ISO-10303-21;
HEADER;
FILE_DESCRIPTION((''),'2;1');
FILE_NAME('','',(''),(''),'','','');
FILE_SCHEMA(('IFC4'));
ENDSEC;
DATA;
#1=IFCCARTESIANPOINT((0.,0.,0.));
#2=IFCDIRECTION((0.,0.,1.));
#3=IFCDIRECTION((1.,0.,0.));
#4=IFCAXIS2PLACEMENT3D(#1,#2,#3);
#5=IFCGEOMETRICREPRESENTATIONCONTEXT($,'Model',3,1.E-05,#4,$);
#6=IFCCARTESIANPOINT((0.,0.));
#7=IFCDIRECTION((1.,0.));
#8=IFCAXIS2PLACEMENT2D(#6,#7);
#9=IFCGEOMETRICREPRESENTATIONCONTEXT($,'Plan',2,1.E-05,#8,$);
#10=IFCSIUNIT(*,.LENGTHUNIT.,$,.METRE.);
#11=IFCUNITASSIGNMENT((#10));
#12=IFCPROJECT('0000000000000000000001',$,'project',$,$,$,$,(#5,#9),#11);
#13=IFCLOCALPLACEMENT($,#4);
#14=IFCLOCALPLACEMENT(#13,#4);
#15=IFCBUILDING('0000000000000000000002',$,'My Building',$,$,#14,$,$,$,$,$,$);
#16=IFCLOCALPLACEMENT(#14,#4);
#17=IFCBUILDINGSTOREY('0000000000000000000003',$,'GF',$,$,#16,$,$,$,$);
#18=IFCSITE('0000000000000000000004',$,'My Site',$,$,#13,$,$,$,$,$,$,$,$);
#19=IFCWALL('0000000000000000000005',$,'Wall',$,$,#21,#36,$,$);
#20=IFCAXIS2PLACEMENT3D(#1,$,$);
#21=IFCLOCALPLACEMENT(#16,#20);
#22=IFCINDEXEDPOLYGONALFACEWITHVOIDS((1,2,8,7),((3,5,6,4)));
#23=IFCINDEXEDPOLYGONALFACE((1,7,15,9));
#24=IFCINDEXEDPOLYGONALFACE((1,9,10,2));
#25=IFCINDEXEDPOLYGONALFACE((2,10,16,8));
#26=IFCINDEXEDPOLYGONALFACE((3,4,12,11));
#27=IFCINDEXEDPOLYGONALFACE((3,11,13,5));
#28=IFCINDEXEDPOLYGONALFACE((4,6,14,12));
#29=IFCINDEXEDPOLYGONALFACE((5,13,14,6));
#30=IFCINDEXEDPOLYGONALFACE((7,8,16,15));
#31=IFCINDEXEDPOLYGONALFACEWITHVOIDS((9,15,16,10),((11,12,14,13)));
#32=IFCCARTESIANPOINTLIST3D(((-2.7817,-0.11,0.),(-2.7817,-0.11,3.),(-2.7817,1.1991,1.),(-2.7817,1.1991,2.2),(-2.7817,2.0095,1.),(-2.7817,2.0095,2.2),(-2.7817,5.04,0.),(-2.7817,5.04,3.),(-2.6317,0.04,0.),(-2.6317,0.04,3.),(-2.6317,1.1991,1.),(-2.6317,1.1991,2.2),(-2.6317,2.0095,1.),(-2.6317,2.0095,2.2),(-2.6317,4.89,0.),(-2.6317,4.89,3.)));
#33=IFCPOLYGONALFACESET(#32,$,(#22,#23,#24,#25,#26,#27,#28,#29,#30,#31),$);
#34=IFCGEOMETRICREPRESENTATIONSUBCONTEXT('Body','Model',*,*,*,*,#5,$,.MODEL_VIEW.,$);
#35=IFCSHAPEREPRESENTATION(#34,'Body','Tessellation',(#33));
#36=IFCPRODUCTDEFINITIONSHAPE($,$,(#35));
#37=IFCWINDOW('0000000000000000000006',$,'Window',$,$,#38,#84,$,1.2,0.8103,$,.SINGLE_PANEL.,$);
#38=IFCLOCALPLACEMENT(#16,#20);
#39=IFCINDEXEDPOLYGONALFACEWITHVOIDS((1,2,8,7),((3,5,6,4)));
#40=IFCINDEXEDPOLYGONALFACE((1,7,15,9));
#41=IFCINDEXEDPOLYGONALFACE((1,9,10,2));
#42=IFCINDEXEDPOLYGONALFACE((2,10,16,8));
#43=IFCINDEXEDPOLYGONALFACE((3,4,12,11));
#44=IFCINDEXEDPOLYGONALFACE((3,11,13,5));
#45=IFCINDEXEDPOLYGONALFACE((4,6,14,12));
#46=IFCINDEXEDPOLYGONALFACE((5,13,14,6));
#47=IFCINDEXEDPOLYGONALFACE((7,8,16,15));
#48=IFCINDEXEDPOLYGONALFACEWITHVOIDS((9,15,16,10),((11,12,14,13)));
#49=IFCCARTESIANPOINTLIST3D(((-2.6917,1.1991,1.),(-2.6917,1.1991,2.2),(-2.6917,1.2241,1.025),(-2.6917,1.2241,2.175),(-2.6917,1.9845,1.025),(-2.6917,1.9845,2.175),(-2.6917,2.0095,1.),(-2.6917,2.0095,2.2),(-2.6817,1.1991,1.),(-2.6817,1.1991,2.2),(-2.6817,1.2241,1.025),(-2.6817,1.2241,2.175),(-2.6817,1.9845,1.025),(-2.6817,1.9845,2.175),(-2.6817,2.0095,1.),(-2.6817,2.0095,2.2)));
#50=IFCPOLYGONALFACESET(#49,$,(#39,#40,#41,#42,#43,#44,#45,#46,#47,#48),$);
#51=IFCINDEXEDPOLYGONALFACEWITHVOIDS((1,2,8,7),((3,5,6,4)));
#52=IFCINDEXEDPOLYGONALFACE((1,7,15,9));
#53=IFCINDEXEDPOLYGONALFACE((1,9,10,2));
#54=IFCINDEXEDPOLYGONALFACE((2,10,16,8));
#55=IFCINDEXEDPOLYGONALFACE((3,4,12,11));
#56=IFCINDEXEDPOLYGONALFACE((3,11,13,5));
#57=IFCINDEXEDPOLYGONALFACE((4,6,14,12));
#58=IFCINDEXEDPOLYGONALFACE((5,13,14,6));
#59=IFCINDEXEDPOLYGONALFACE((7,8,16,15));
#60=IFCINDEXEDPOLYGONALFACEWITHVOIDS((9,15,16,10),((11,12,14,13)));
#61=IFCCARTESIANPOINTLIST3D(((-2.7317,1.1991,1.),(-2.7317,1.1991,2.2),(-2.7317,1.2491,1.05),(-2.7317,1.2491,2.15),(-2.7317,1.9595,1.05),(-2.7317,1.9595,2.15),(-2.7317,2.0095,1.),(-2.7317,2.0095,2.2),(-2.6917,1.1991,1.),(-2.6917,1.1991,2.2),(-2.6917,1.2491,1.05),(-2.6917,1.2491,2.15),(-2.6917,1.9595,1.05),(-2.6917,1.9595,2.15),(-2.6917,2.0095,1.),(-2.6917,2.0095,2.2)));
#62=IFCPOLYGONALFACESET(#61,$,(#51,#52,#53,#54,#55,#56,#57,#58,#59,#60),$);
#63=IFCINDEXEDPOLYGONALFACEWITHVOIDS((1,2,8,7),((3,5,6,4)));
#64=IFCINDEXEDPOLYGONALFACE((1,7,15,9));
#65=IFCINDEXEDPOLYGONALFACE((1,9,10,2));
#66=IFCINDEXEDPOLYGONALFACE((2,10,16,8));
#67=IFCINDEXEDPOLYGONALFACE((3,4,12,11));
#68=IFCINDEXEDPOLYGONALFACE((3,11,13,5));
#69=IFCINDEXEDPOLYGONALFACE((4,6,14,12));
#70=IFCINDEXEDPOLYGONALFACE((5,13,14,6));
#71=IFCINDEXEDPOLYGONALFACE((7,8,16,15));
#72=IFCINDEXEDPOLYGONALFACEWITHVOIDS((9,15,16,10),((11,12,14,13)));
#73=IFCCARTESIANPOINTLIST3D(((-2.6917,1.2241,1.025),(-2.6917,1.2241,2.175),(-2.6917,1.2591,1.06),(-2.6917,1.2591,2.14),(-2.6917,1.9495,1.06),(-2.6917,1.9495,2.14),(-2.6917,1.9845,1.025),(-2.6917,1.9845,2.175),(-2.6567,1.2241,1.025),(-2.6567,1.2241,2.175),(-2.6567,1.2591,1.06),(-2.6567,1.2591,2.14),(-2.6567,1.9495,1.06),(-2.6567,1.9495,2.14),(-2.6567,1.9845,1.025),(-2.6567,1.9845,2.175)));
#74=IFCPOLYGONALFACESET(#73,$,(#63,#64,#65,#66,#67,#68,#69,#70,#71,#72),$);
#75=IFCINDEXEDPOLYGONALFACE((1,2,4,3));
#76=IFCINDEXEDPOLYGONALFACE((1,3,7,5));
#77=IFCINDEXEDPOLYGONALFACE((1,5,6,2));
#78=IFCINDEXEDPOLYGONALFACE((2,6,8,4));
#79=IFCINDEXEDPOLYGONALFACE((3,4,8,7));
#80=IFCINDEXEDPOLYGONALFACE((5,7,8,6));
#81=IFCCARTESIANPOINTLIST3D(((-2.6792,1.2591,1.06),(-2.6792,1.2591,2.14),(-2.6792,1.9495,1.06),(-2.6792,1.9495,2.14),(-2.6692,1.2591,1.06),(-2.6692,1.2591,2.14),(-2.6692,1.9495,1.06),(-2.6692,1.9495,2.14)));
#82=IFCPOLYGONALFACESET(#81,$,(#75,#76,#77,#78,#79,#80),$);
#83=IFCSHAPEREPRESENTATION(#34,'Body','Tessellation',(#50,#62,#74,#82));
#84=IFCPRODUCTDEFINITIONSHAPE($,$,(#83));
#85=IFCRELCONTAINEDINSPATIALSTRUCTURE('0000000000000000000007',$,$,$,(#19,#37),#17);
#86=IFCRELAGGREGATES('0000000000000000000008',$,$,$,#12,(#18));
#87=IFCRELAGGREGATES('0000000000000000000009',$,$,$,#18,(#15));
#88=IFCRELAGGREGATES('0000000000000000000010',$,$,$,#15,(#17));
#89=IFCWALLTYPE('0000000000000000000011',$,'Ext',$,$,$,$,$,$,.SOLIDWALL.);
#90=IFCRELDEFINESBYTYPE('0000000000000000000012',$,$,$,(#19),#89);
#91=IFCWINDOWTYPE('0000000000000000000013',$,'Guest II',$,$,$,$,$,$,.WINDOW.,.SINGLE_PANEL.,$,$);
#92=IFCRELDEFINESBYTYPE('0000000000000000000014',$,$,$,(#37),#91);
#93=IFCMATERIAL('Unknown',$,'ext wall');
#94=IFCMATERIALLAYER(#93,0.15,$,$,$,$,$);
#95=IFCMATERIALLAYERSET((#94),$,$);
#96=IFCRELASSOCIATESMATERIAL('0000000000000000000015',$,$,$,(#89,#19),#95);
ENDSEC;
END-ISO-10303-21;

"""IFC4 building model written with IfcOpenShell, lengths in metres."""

from ifc_helpers import new_model, entity, si_unit, frame, origin_with_axes, origin_2d_with_axis, place, context, subcontext, project, spatial, line, indexed_curve, outline, extrude, shape, source, transform, mapped, material, layer, layer_set, layer_usage, type_object, type_shapes, element, fill, save


model = new_model("IFC4")

# Units and contexts
model_context = context("Model", 3, precision=1e-05, world=origin_with_axes())
plan_context = context("Plan", 2, precision=1e-05, world=origin_2d_with_axis())
body_context_1 = subcontext(model_context, "Body", "Model", "MODEL_VIEW")
body_context_2 = subcontext(plan_context, "Body", "Plan", "PLAN_VIEW")
ifc_project = project(units=[si_unit("LENGTHUNIT", "METRE")], contexts=[model_context, plan_context])

# Site, building, storey
site_placement = place(None, origin_with_axes())
site = spatial("IfcSite", under=ifc_project, at=site_placement, Name="My Site")
building_placement = place(site_placement, origin_with_axes())
building = spatial("IfcBuilding", under=site, at=building_placement, Name="My Building")
storey_placement = place(building_placement, origin_with_axes())
storey = spatial("IfcBuildingStorey", under=building, at=storey_placement, Name="GF")

# Shared definitions
ifc_material = material(Name="Unknown", Category="ext wall")

# Shared definitions
ifc_layer_1 = layer(ifc_material, 0.15)
ifc_layer_set_1 = layer_set([ifc_layer_1])
wall_type_1 = type_object("IfcWallType", Name="Ext", PredefinedType="SOLIDWALL", material=ifc_layer_set_1)

# Wall, opening, window
ifc_layer_usage_1 = layer_usage(ifc_layer_set_1, "AXIS2", "POSITIVE", 0.0)
wall_1_placement = place(storey_placement, frame((-2.7817, 5.04, 0.0), z_axis=(0.0, 0.0, 1.0), x_axis=(0.0, -1.0, 0.0)))
wall_1 = element("IfcWall", 1, at=wall_1_placement, inside=storey, type_object=wall_type_1, material=ifc_layer_usage_1, Name="Wall", context=body_context_1, shape_type="SweptSolid", body=[
    extrude(outline(indexed_curve([(0.0, 0.0), (0.15, 0.15), (5.0, 0.15), (5.15, 0.0)], segments=[line(1, 2, 3, 4, 1)])), origin_with_axes(), (0.0, 0.0, 1.0), 3.0),
])
shared_shape_1 = source(origin_with_axes(), body_context_1, "Body", "SweptSolid", [
    extrude(outline(indexed_curve([(0.0, 0.0), (0.8103, 0.0), (0.8103, 1.2), (0.0, 1.2)], segments=[line(1, 2, 3, 4, 1)])), frame((0.0, -0.6, 0.0), z_axis=(0.0, -1.0, 0.0), x_axis=(1.0, 0.0, 0.0)), (0.0, 0.0, -1.0), 1.2),
])
opening_1_placement = place(wall_1_placement, frame((3.0305, 0.0, 1.0), z_axis=(0.0, 0.0, 1.0), x_axis=(1.0, 0.0, 0.0)))
opening_1 = element("IfcOpeningElement", 2, at=opening_1_placement, cuts=wall_1, PredefinedType="OPENING", context=body_context_1, shape_type="MappedRepresentation", body=[
    mapped(shared_shape_1, transform((0.0, 0.0, 0.0), x_axis=(1.0, 0.0, 0.0), y_axis=(0.0, 1.0, 0.0), z_axis=(0.0, 0.0, 1.0), scale=1.0)),
])
window_type_1 = type_object("IfcWindowType", Name="Guest II", PartitioningType="SINGLE_PANEL", PredefinedType="WINDOW")
shared_shape_2 = source(origin_with_axes(), body_context_1, "Body", "SweptSolid", [
    extrude(outline(indexed_curve([(0.0, 0.0), (0.8103, 0.0), (0.8103, 1.2), (0.0, 1.2)], segments=[line(1, 2, 3, 4, 1)]), holes=[indexed_curve([(0.025, 0.025), (0.7853, 0.025), (0.7853, 1.175), (0.025, 1.175)], segments=[line(1, 2, 3, 4, 1)])]), frame((0.0, 0.09, 0.0), z_axis=(0.0, -1.0, 0.0), x_axis=(1.0, 0.0, 0.0)), (0.0, 0.0, -1.0), 0.01),
    extrude(outline(indexed_curve([(0.0, 0.0), (0.8103, 0.0), (0.8103, 1.2), (0.0, 1.2)], segments=[line(1, 2, 3, 4, 1)]), holes=[indexed_curve([(0.05, 0.05), (0.7603, 0.05), (0.7603, 1.15), (0.05, 1.15)], segments=[line(1, 2, 3, 4, 1)])]), frame((0.0, 0.05, 0.0), z_axis=(0.0, -1.0, 0.0), x_axis=(1.0, 0.0, 0.0)), (0.0, 0.0, -1.0), 0.04),
    extrude(outline(indexed_curve([(0.0, 0.0), (0.7603, 0.0), (0.7603, 1.15), (0.0, 1.15)], segments=[line(1, 2, 3, 4, 1)]), holes=[indexed_curve([(0.035, 0.035), (0.7253, 0.035), (0.7253, 1.115), (0.035, 1.115)], segments=[line(1, 2, 3, 4, 1)])]), frame((0.025, 0.09, 0.025), z_axis=(0.0, -1.0, 0.0), x_axis=(1.0, 0.0, 0.0)), (0.0, 0.0, -1.0), 0.035),
    extrude(outline(indexed_curve([(0.035, 0.035), (0.7253, 0.035), (0.7253, 1.115), (0.035, 1.115)], segments=[line(1, 2, 3, 4, 1)])), frame((0.025, 0.1025, 0.025), z_axis=(0.0, -1.0, 0.0), x_axis=(1.0, 0.0, 0.0)), (0.0, 0.0, -1.0), 0.01),
])
shared_shape_3 = source(origin_with_axes(), body_context_2, "Body", "Curve2D", [
    entity("IfcIndexedPolyCurve", entity("IfcCartesianPointList2D", [[0.05, 0.05], [0.7603, 0.05]])),
    entity("IfcIndexedPolyCurve", entity("IfcCartesianPointList2D", [[0.0, 0.1], [0.025, 0.1], [0.025, 0.09], [0.05, 0.09], [0.05, 0.05], [0.0, 0.05]]), [entity("IfcLineIndex", [1, 2, 3, 4, 5, 6, 1])]),
    entity("IfcIndexedPolyCurve", entity("IfcCartesianPointList2D", [[0.8103, 0.1], [0.7853, 0.1], [0.7853, 0.09], [0.7603, 0.09], [0.7603, 0.05], [0.8103, 0.05]]), [entity("IfcLineIndex", [1, 2, 3, 4, 5, 6, 1])]),
    entity("IfcIndexedPolyCurve", entity("IfcCartesianPointList2D", [[0.025, 0.09], [0.06, 0.09], [0.06, 0.125], [0.025, 0.125]]), [entity("IfcLineIndex", [1, 2, 3, 4, 1])]),
    entity("IfcIndexedPolyCurve", entity("IfcCartesianPointList2D", [[0.7853, 0.09], [0.7503, 0.09], [0.7503, 0.125], [0.7853, 0.125]]), [entity("IfcLineIndex", [1, 2, 3, 4, 1])]),
    entity("IfcIndexedPolyCurve", entity("IfcCartesianPointList2D", [[0.06, 0.09], [0.7503, 0.09]])),
    entity("IfcIndexedPolyCurve", entity("IfcCartesianPointList2D", [[0.06, 0.125], [0.7503, 0.125]])),
    entity("IfcIndexedPolyCurve", entity("IfcCartesianPointList2D", [[0.06, 0.1075], [0.7503, 0.1075]])),
])
type_shapes(window_type_1, [shared_shape_2, shared_shape_3])
window_1_placement = place(opening_1_placement, frame((0.0, 0.0, 0.0), z_axis=(0.0, 0.0, 1.0), x_axis=(1.0, 0.0, 0.0)))
window_1 = element("IfcWindow", 3, at=window_1_placement, inside=storey, type_object=window_type_1, Name="Window", OverallHeight=1.2, OverallWidth=0.8103, PartitioningType="SINGLE_PANEL", shapes=[
    shape(body_context_1, "Body", "MappedRepresentation", [mapped(shared_shape_2, transform((0.0, 0.0, 0.0), x_axis=(1.0, 0.0, 0.0), y_axis=(0.0, 1.0, 0.0), z_axis=(0.0, 0.0, 1.0), scale=1.0))]),
    shape(body_context_2, "Body", "MappedRepresentation", [mapped(shared_shape_3, transform((0.0, 0.0, 0.0), x_axis=(1.0, 0.0, 0.0), y_axis=(0.0, 1.0, 0.0), z_axis=(0.0, 0.0, 1.0), scale=1.0))]),
])
fill(opening_1, window_1)

save(model, "model.ifc")
